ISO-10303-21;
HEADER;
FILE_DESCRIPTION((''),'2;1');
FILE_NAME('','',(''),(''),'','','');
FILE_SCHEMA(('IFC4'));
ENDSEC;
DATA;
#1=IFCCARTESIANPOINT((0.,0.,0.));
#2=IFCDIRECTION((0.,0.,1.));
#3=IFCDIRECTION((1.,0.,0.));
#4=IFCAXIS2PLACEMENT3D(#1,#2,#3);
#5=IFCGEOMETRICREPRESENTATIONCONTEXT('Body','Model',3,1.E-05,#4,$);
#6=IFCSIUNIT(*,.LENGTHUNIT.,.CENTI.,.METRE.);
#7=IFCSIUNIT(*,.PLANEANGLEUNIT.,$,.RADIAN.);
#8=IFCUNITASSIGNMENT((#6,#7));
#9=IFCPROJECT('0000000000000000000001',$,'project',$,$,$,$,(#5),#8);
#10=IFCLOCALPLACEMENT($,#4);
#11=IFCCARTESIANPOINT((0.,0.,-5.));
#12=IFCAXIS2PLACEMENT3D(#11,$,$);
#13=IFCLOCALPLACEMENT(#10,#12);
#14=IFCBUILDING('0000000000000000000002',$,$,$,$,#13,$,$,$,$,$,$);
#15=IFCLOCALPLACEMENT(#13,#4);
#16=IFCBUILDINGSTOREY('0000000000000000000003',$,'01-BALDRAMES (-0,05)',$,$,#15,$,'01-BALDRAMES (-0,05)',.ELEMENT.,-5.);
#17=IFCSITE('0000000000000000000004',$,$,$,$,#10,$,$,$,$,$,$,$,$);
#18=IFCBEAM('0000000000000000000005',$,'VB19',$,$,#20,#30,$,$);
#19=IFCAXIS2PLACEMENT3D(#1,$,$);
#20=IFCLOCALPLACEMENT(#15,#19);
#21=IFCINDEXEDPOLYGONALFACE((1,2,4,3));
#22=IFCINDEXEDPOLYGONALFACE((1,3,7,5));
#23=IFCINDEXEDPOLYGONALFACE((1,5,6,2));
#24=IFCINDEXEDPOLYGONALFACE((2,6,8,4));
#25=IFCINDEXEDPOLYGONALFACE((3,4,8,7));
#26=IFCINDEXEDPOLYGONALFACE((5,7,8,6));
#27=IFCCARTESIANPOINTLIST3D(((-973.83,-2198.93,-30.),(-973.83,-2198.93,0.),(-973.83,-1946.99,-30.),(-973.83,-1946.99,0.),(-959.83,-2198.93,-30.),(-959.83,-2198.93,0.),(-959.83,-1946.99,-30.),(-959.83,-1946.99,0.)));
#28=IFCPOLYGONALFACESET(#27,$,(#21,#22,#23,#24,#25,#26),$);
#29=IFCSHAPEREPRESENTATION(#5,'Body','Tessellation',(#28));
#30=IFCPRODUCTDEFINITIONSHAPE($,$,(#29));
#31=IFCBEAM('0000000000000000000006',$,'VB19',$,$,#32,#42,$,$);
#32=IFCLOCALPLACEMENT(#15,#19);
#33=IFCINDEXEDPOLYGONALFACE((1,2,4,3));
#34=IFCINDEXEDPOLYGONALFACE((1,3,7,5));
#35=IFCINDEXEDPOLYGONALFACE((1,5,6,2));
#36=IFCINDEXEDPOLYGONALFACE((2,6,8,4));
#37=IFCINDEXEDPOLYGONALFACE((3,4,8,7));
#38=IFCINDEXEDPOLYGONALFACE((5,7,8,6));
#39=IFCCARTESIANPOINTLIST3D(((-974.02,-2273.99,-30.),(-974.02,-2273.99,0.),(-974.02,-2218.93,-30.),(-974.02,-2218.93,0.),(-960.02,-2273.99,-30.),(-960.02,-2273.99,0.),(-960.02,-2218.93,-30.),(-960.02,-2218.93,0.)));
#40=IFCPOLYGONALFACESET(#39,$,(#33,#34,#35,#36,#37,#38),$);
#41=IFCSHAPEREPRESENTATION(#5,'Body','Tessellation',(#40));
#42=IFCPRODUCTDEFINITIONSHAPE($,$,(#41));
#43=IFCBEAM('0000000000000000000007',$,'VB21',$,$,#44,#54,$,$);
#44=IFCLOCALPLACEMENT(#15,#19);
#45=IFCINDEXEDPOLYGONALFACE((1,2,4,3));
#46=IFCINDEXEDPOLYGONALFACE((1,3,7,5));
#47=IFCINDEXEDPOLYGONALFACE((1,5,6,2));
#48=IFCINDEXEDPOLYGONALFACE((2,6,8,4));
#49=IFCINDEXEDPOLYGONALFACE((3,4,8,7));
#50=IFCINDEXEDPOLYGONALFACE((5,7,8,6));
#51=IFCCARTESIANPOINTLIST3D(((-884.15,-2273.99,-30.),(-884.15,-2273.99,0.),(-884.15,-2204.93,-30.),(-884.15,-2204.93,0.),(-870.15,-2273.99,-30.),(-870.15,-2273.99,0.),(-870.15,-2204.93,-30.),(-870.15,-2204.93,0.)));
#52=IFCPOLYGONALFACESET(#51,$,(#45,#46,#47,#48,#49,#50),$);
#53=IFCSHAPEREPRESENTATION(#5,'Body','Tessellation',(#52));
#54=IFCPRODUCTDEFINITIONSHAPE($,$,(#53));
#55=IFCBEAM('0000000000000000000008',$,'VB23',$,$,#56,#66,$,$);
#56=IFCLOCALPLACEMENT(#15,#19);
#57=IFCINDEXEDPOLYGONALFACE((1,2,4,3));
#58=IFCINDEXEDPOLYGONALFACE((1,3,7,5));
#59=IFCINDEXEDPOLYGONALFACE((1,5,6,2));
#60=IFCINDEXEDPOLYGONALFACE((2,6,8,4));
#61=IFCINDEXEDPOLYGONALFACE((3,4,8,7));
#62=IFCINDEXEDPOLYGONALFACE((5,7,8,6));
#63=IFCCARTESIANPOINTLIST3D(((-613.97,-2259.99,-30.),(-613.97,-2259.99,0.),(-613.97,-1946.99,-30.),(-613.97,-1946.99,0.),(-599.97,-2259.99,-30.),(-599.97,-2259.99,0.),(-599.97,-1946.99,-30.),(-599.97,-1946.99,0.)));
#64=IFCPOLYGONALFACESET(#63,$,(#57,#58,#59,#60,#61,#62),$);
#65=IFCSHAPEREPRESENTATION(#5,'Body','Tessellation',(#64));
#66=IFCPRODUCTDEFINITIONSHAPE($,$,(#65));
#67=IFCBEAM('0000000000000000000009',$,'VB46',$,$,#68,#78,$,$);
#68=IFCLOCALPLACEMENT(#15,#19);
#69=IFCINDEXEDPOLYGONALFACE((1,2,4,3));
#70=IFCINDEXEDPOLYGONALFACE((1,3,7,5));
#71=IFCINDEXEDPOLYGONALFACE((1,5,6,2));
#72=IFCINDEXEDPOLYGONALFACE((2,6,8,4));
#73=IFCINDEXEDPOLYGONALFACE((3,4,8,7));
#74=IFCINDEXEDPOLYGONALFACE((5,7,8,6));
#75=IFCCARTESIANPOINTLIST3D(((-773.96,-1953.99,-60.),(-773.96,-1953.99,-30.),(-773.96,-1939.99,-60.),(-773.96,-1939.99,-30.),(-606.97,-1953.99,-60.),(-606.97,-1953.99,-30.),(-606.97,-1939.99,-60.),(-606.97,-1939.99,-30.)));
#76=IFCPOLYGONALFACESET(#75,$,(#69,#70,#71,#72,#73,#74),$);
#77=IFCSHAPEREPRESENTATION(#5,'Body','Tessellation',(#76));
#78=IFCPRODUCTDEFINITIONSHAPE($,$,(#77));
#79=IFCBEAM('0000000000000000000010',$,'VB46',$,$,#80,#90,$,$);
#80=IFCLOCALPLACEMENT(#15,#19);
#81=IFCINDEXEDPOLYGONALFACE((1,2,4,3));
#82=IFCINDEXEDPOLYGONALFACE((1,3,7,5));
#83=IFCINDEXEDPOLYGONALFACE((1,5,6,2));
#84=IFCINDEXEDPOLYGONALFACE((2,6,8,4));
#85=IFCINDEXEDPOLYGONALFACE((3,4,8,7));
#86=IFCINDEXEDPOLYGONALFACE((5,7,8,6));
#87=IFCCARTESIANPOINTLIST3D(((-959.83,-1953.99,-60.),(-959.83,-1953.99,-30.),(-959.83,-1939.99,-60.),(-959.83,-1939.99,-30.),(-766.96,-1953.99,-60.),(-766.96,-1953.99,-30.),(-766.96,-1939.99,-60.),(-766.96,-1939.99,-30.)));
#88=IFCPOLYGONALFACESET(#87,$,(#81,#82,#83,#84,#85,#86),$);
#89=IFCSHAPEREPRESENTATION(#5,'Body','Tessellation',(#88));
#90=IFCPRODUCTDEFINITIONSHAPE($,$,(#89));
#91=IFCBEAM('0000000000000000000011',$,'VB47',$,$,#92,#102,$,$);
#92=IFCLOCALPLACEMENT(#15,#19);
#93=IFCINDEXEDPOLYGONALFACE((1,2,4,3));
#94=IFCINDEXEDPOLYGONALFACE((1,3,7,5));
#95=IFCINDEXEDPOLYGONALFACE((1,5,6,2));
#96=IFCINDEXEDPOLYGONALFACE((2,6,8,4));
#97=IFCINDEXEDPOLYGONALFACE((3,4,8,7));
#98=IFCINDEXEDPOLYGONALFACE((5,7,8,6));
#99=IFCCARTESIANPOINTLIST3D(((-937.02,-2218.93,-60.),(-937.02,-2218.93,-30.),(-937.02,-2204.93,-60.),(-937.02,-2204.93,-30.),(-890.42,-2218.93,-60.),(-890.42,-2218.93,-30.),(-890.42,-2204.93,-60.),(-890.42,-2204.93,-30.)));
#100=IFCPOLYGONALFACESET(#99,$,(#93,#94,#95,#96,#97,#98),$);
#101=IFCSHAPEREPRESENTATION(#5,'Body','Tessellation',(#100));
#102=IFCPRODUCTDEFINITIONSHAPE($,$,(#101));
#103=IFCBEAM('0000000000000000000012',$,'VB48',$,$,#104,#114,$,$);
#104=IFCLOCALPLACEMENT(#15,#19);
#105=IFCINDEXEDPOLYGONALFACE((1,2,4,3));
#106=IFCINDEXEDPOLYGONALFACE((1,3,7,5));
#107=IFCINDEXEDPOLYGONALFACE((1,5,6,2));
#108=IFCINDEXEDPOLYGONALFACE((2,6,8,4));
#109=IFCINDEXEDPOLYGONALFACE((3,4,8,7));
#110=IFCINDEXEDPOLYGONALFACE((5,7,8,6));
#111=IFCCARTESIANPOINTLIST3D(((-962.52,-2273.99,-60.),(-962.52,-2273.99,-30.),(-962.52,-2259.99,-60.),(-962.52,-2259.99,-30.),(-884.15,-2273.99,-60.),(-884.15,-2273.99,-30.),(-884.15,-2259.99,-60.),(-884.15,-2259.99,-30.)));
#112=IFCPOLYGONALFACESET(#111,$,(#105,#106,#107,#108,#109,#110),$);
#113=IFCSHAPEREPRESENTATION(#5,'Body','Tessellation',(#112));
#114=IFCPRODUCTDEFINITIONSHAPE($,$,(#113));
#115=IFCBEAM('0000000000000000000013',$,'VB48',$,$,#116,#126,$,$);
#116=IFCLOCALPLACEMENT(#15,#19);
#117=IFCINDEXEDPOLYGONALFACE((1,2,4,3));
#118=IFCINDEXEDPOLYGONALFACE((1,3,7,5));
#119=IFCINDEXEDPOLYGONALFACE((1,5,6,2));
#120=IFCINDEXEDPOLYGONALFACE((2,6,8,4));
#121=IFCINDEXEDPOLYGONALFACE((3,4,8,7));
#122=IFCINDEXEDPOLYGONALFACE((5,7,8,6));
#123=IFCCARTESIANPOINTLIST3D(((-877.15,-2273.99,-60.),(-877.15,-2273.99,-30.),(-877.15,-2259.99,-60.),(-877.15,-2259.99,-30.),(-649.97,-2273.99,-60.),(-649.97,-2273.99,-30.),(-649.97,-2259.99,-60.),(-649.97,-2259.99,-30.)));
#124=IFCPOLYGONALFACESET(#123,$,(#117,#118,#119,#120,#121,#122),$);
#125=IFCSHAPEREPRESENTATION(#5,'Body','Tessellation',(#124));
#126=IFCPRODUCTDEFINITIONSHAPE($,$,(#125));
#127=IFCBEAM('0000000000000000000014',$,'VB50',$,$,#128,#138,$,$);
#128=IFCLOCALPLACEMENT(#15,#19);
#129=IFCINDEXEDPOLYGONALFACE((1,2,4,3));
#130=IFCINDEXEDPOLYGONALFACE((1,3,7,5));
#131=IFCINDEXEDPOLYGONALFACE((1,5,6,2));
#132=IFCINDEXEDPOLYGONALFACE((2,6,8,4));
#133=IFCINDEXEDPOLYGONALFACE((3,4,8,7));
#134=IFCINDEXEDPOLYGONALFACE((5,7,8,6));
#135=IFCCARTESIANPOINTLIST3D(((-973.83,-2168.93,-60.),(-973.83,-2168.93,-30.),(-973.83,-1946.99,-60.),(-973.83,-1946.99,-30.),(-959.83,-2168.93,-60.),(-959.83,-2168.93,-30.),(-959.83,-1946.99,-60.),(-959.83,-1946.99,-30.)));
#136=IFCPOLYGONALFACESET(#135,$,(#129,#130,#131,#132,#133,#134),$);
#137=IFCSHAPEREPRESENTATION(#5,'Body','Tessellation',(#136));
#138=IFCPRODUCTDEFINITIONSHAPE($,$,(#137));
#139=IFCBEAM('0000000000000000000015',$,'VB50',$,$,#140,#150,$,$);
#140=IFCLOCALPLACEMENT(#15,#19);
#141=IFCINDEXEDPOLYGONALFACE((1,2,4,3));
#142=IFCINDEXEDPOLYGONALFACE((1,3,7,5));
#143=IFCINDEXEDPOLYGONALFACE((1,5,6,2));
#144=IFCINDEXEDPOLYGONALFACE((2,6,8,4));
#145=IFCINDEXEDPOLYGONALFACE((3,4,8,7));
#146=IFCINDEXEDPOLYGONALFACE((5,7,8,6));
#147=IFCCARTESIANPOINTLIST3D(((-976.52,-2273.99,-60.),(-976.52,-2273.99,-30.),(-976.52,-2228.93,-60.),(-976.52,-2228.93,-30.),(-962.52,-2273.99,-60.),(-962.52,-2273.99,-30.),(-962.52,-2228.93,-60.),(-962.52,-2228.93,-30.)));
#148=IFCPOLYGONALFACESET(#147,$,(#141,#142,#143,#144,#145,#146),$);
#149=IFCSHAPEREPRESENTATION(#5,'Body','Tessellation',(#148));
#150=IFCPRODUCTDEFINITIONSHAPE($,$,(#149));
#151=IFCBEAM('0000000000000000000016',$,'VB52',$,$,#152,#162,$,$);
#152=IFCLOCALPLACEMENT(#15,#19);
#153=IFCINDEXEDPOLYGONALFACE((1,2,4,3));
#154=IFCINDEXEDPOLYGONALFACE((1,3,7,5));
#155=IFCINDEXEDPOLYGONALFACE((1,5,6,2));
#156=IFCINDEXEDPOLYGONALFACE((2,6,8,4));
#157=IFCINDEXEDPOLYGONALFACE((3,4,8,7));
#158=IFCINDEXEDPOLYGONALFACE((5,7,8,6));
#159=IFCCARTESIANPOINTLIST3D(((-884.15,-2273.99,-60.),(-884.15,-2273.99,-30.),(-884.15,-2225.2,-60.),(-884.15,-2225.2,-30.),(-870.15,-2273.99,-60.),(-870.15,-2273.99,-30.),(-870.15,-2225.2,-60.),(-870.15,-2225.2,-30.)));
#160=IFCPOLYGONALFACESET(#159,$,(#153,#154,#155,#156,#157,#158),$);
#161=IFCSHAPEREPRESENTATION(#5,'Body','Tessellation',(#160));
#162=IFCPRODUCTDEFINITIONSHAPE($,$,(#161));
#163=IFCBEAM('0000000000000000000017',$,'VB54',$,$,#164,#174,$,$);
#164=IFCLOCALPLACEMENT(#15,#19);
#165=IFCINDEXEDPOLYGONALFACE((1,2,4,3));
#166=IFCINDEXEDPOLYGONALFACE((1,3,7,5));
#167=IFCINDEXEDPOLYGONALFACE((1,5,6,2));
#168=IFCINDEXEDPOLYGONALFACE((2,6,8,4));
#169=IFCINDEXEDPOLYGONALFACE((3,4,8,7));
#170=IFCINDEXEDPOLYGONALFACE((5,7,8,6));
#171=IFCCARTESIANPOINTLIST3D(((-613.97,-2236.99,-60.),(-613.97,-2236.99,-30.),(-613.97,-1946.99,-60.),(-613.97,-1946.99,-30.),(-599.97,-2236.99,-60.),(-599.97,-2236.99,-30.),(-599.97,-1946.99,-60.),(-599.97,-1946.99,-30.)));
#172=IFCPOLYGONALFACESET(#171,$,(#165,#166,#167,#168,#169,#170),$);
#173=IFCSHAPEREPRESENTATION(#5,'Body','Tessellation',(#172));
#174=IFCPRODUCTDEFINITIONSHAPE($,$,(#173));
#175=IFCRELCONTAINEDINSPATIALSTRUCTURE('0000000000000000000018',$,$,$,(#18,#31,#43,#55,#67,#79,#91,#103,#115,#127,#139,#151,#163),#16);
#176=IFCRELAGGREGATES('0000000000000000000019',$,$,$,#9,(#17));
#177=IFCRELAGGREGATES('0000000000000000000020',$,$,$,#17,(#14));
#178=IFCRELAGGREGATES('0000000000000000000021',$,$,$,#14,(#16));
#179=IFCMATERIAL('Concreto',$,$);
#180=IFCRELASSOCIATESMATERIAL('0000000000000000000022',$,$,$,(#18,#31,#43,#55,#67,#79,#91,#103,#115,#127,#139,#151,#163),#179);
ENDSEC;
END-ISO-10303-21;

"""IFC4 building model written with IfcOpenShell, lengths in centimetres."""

from ifc_helpers import new_model, si_unit, frame, origin_with_axes, origin_2d_with_axis, place, context, project, spatial, rectangle, extrude, material, element, save


model = new_model("IFC4")

# Units and contexts
model_context = context("Model", 3, precision=1e-05, world=origin_with_axes(), identifier="Body")
ifc_project = project(units=[si_unit("LENGTHUNIT", "METRE", prefix="CENTI"), si_unit("PLANEANGLEUNIT", "RADIAN")], contexts=[model_context])

# Site, building, storey
site_placement = place(None, origin_with_axes())
site = spatial("IfcSite", under=ifc_project, at=site_placement)
building_placement = place(site_placement, frame((0.0, 0.0, -5.0)))
building = spatial("IfcBuilding", under=site, at=building_placement)
storey_placement = place(building_placement, origin_with_axes())
storey = spatial("IfcBuildingStorey", under=building, at=storey_placement, Name="01-BALDRAMES (-0,05)", LongName="01-BALDRAMES (-0,05)", CompositionType="ELEMENT", Elevation=-5.0)

# Shared definitions
ifc_material = material(Name="Concreto")

# Beams
beam_1_placement = place(storey_placement, frame((-966.83, -2072.96, 0.0), z_axis=(0.0, 0.0, 1.0), x_axis=(1.0, 0.0, 0.0)))
element("IfcBeam", 1, at=beam_1_placement, inside=storey, material=ifc_material, Name="VB19", context=model_context, shape_type="SolidModel", body=[
    extrude(rectangle(XDim=14.0, YDim=30.0, at=origin_2d_with_axis()), frame((0.0, -125.97, -15.0), z_axis=(0.0, 1.0, 0.0), x_axis=(1.0, 0.0, 0.0)), (0.0, 0.0, 1.0), 251.94),
])
beam_2_placement = place(storey_placement, frame((-967.02, -2246.46, 0.0), z_axis=(0.0, 0.0, 1.0), x_axis=(1.0, 0.0, 0.0)))
element("IfcBeam", 2, at=beam_2_placement, inside=storey, material=ifc_material, Name="VB19", context=model_context, shape_type="SolidModel", body=[
    extrude(rectangle(XDim=14.0, YDim=30.0, at=origin_2d_with_axis()), frame((0.0, -27.53, -15.0), z_axis=(0.0, 1.0, 0.0), x_axis=(1.0, 0.0, 0.0)), (0.0, 0.0, 1.0), 55.06),
])
beam_3_placement = place(storey_placement, frame((-877.15, -2239.46, 0.0), z_axis=(0.0, 0.0, 1.0), x_axis=(1.0, 0.0, 0.0)))
element("IfcBeam", 3, at=beam_3_placement, inside=storey, material=ifc_material, Name="VB21", context=model_context, shape_type="SolidModel", body=[
    extrude(rectangle(XDim=14.0, YDim=30.0, at=origin_2d_with_axis()), frame((0.0, -34.53, -15.0), z_axis=(0.0, 1.0, 0.0), x_axis=(1.0, 0.0, 0.0)), (0.0, 0.0, 1.0), 69.06),
])
beam_4_placement = place(storey_placement, frame((-606.97, -2103.49, 0.0), z_axis=(0.0, 0.0, 1.0), x_axis=(1.0, 0.0, 0.0)))
element("IfcBeam", 4, at=beam_4_placement, inside=storey, material=ifc_material, Name="VB23", context=model_context, shape_type="SolidModel", body=[
    extrude(rectangle(XDim=14.0, YDim=30.0, at=origin_2d_with_axis()), frame((0.0, -156.5, -15.0), z_axis=(0.0, 1.0, 0.0), x_axis=(1.0, 0.0, 0.0)), (0.0, 0.0, 1.0), 313.0),
])
beam_5_placement = place(storey_placement, frame((-690.47, -1946.99, -30.0), z_axis=(0.0, 0.0, 1.0), x_axis=(1.0, 0.0, 0.0)))
element("IfcBeam", 5, at=beam_5_placement, inside=storey, material=ifc_material, Name="VB46", context=model_context, shape_type="SolidModel", body=[
    extrude(rectangle(XDim=14.0, YDim=30.0, at=origin_2d_with_axis()), frame((-83.5, 0.0, -15.0), z_axis=(1.0, 0.0, 0.0), x_axis=(0.0, -1.0, 0.0)), (0.0, 0.0, 1.0), 166.99),
])
beam_6_placement = place(storey_placement, frame((-863.39, -1946.99, -30.0), z_axis=(0.0, 0.0, 1.0), x_axis=(1.0, 0.0, 0.0)))
element("IfcBeam", 6, at=beam_6_placement, inside=storey, material=ifc_material, Name="VB46", context=model_context, shape_type="SolidModel", body=[
    extrude(rectangle(XDim=14.0, YDim=30.0, at=origin_2d_with_axis()), frame((-96.44, 0.0, -15.0), z_axis=(1.0, 0.0, 0.0), x_axis=(0.0, -1.0, 0.0)), (0.0, 0.0, 1.0), 192.87),
])
beam_7_placement = place(storey_placement, frame((-913.72, -2211.93, -30.0), z_axis=(0.0, 0.0, 1.0), x_axis=(1.0, 0.0, 0.0)))
element("IfcBeam", 7, at=beam_7_placement, inside=storey, material=ifc_material, Name="VB47", context=model_context, shape_type="SolidModel", body=[
    extrude(rectangle(XDim=14.0, YDim=30.0, at=origin_2d_with_axis()), frame((-23.3, 0.0, -15.0), z_axis=(1.0, 0.0, 0.0), x_axis=(0.0, -1.0, 0.0)), (0.0, 0.0, 1.0), 46.6),
])
beam_8_placement = place(storey_placement, frame((-923.34, -2266.99, -30.0), z_axis=(0.0, 0.0, 1.0), x_axis=(1.0, 0.0, 0.0)))
element("IfcBeam", 8, at=beam_8_placement, inside=storey, material=ifc_material, Name="VB48", context=model_context, shape_type="SolidModel", body=[
    extrude(rectangle(XDim=14.0, YDim=30.0, at=origin_2d_with_axis()), frame((-39.19, 0.0, -15.0), z_axis=(1.0, 0.0, 0.0), x_axis=(0.0, -1.0, 0.0)), (0.0, 0.0, 1.0), 78.37),
])
beam_9_placement = place(storey_placement, frame((-763.56, -2266.99, -30.0), z_axis=(0.0, 0.0, 1.0), x_axis=(1.0, 0.0, 0.0)))
element("IfcBeam", 9, at=beam_9_placement, inside=storey, material=ifc_material, Name="VB48", context=model_context, shape_type="SolidModel", body=[
    extrude(rectangle(XDim=14.0, YDim=30.0, at=origin_2d_with_axis()), frame((-113.59, 0.0, -15.0), z_axis=(1.0, 0.0, 0.0), x_axis=(0.0, -1.0, 0.0)), (0.0, 0.0, 1.0), 227.18),
])
beam_10_placement = place(storey_placement, frame((-966.83, -2057.96, -30.0), z_axis=(0.0, 0.0, 1.0), x_axis=(1.0, 0.0, 0.0)))
element("IfcBeam", 10, at=beam_10_placement, inside=storey, material=ifc_material, Name="VB50", context=model_context, shape_type="SolidModel", body=[
    extrude(rectangle(XDim=14.0, YDim=30.0, at=origin_2d_with_axis()), frame((0.0, -110.97, -15.0), z_axis=(0.0, 1.0, 0.0), x_axis=(1.0, 0.0, 0.0)), (0.0, 0.0, 1.0), 221.94),
])
beam_11_placement = place(storey_placement, frame((-969.52, -2251.46, -30.0), z_axis=(0.0, 0.0, 1.0), x_axis=(1.0, 0.0, 0.0)))
element("IfcBeam", 11, at=beam_11_placement, inside=storey, material=ifc_material, Name="VB50", context=model_context, shape_type="SolidModel", body=[
    extrude(rectangle(XDim=14.0, YDim=30.0, at=origin_2d_with_axis()), frame((0.0, -22.53, -15.0), z_axis=(0.0, 1.0, 0.0), x_axis=(1.0, 0.0, 0.0)), (0.0, 0.0, 1.0), 45.06),
])
beam_12_placement = place(storey_placement, frame((-877.15, -2249.59, -30.0), z_axis=(0.0, 0.0, 1.0), x_axis=(1.0, 0.0, 0.0)))
element("IfcBeam", 12, at=beam_12_placement, inside=storey, material=ifc_material, Name="VB52", context=model_context, shape_type="SolidModel", body=[
    extrude(rectangle(XDim=14.0, YDim=30.0, at=origin_2d_with_axis()), frame((0.0, -24.4, -15.0), z_axis=(0.0, 1.0, 0.0), x_axis=(1.0, 0.0, 0.0)), (0.0, 0.0, 1.0), 48.79),
])
beam_13_placement = place(storey_placement, frame((-606.97, -2091.99, -30.0), z_axis=(0.0, 0.0, 1.0), x_axis=(1.0, 0.0, 0.0)))
element("IfcBeam", 13, at=beam_13_placement, inside=storey, material=ifc_material, Name="VB54", context=model_context, shape_type="SolidModel", body=[
    extrude(rectangle(XDim=14.0, YDim=30.0, at=origin_2d_with_axis()), frame((0.0, -145.0, -15.0), z_axis=(0.0, 1.0, 0.0), x_axis=(1.0, 0.0, 0.0)), (0.0, 0.0, 1.0), 290.0),
])

save(model, "model.ifc")
